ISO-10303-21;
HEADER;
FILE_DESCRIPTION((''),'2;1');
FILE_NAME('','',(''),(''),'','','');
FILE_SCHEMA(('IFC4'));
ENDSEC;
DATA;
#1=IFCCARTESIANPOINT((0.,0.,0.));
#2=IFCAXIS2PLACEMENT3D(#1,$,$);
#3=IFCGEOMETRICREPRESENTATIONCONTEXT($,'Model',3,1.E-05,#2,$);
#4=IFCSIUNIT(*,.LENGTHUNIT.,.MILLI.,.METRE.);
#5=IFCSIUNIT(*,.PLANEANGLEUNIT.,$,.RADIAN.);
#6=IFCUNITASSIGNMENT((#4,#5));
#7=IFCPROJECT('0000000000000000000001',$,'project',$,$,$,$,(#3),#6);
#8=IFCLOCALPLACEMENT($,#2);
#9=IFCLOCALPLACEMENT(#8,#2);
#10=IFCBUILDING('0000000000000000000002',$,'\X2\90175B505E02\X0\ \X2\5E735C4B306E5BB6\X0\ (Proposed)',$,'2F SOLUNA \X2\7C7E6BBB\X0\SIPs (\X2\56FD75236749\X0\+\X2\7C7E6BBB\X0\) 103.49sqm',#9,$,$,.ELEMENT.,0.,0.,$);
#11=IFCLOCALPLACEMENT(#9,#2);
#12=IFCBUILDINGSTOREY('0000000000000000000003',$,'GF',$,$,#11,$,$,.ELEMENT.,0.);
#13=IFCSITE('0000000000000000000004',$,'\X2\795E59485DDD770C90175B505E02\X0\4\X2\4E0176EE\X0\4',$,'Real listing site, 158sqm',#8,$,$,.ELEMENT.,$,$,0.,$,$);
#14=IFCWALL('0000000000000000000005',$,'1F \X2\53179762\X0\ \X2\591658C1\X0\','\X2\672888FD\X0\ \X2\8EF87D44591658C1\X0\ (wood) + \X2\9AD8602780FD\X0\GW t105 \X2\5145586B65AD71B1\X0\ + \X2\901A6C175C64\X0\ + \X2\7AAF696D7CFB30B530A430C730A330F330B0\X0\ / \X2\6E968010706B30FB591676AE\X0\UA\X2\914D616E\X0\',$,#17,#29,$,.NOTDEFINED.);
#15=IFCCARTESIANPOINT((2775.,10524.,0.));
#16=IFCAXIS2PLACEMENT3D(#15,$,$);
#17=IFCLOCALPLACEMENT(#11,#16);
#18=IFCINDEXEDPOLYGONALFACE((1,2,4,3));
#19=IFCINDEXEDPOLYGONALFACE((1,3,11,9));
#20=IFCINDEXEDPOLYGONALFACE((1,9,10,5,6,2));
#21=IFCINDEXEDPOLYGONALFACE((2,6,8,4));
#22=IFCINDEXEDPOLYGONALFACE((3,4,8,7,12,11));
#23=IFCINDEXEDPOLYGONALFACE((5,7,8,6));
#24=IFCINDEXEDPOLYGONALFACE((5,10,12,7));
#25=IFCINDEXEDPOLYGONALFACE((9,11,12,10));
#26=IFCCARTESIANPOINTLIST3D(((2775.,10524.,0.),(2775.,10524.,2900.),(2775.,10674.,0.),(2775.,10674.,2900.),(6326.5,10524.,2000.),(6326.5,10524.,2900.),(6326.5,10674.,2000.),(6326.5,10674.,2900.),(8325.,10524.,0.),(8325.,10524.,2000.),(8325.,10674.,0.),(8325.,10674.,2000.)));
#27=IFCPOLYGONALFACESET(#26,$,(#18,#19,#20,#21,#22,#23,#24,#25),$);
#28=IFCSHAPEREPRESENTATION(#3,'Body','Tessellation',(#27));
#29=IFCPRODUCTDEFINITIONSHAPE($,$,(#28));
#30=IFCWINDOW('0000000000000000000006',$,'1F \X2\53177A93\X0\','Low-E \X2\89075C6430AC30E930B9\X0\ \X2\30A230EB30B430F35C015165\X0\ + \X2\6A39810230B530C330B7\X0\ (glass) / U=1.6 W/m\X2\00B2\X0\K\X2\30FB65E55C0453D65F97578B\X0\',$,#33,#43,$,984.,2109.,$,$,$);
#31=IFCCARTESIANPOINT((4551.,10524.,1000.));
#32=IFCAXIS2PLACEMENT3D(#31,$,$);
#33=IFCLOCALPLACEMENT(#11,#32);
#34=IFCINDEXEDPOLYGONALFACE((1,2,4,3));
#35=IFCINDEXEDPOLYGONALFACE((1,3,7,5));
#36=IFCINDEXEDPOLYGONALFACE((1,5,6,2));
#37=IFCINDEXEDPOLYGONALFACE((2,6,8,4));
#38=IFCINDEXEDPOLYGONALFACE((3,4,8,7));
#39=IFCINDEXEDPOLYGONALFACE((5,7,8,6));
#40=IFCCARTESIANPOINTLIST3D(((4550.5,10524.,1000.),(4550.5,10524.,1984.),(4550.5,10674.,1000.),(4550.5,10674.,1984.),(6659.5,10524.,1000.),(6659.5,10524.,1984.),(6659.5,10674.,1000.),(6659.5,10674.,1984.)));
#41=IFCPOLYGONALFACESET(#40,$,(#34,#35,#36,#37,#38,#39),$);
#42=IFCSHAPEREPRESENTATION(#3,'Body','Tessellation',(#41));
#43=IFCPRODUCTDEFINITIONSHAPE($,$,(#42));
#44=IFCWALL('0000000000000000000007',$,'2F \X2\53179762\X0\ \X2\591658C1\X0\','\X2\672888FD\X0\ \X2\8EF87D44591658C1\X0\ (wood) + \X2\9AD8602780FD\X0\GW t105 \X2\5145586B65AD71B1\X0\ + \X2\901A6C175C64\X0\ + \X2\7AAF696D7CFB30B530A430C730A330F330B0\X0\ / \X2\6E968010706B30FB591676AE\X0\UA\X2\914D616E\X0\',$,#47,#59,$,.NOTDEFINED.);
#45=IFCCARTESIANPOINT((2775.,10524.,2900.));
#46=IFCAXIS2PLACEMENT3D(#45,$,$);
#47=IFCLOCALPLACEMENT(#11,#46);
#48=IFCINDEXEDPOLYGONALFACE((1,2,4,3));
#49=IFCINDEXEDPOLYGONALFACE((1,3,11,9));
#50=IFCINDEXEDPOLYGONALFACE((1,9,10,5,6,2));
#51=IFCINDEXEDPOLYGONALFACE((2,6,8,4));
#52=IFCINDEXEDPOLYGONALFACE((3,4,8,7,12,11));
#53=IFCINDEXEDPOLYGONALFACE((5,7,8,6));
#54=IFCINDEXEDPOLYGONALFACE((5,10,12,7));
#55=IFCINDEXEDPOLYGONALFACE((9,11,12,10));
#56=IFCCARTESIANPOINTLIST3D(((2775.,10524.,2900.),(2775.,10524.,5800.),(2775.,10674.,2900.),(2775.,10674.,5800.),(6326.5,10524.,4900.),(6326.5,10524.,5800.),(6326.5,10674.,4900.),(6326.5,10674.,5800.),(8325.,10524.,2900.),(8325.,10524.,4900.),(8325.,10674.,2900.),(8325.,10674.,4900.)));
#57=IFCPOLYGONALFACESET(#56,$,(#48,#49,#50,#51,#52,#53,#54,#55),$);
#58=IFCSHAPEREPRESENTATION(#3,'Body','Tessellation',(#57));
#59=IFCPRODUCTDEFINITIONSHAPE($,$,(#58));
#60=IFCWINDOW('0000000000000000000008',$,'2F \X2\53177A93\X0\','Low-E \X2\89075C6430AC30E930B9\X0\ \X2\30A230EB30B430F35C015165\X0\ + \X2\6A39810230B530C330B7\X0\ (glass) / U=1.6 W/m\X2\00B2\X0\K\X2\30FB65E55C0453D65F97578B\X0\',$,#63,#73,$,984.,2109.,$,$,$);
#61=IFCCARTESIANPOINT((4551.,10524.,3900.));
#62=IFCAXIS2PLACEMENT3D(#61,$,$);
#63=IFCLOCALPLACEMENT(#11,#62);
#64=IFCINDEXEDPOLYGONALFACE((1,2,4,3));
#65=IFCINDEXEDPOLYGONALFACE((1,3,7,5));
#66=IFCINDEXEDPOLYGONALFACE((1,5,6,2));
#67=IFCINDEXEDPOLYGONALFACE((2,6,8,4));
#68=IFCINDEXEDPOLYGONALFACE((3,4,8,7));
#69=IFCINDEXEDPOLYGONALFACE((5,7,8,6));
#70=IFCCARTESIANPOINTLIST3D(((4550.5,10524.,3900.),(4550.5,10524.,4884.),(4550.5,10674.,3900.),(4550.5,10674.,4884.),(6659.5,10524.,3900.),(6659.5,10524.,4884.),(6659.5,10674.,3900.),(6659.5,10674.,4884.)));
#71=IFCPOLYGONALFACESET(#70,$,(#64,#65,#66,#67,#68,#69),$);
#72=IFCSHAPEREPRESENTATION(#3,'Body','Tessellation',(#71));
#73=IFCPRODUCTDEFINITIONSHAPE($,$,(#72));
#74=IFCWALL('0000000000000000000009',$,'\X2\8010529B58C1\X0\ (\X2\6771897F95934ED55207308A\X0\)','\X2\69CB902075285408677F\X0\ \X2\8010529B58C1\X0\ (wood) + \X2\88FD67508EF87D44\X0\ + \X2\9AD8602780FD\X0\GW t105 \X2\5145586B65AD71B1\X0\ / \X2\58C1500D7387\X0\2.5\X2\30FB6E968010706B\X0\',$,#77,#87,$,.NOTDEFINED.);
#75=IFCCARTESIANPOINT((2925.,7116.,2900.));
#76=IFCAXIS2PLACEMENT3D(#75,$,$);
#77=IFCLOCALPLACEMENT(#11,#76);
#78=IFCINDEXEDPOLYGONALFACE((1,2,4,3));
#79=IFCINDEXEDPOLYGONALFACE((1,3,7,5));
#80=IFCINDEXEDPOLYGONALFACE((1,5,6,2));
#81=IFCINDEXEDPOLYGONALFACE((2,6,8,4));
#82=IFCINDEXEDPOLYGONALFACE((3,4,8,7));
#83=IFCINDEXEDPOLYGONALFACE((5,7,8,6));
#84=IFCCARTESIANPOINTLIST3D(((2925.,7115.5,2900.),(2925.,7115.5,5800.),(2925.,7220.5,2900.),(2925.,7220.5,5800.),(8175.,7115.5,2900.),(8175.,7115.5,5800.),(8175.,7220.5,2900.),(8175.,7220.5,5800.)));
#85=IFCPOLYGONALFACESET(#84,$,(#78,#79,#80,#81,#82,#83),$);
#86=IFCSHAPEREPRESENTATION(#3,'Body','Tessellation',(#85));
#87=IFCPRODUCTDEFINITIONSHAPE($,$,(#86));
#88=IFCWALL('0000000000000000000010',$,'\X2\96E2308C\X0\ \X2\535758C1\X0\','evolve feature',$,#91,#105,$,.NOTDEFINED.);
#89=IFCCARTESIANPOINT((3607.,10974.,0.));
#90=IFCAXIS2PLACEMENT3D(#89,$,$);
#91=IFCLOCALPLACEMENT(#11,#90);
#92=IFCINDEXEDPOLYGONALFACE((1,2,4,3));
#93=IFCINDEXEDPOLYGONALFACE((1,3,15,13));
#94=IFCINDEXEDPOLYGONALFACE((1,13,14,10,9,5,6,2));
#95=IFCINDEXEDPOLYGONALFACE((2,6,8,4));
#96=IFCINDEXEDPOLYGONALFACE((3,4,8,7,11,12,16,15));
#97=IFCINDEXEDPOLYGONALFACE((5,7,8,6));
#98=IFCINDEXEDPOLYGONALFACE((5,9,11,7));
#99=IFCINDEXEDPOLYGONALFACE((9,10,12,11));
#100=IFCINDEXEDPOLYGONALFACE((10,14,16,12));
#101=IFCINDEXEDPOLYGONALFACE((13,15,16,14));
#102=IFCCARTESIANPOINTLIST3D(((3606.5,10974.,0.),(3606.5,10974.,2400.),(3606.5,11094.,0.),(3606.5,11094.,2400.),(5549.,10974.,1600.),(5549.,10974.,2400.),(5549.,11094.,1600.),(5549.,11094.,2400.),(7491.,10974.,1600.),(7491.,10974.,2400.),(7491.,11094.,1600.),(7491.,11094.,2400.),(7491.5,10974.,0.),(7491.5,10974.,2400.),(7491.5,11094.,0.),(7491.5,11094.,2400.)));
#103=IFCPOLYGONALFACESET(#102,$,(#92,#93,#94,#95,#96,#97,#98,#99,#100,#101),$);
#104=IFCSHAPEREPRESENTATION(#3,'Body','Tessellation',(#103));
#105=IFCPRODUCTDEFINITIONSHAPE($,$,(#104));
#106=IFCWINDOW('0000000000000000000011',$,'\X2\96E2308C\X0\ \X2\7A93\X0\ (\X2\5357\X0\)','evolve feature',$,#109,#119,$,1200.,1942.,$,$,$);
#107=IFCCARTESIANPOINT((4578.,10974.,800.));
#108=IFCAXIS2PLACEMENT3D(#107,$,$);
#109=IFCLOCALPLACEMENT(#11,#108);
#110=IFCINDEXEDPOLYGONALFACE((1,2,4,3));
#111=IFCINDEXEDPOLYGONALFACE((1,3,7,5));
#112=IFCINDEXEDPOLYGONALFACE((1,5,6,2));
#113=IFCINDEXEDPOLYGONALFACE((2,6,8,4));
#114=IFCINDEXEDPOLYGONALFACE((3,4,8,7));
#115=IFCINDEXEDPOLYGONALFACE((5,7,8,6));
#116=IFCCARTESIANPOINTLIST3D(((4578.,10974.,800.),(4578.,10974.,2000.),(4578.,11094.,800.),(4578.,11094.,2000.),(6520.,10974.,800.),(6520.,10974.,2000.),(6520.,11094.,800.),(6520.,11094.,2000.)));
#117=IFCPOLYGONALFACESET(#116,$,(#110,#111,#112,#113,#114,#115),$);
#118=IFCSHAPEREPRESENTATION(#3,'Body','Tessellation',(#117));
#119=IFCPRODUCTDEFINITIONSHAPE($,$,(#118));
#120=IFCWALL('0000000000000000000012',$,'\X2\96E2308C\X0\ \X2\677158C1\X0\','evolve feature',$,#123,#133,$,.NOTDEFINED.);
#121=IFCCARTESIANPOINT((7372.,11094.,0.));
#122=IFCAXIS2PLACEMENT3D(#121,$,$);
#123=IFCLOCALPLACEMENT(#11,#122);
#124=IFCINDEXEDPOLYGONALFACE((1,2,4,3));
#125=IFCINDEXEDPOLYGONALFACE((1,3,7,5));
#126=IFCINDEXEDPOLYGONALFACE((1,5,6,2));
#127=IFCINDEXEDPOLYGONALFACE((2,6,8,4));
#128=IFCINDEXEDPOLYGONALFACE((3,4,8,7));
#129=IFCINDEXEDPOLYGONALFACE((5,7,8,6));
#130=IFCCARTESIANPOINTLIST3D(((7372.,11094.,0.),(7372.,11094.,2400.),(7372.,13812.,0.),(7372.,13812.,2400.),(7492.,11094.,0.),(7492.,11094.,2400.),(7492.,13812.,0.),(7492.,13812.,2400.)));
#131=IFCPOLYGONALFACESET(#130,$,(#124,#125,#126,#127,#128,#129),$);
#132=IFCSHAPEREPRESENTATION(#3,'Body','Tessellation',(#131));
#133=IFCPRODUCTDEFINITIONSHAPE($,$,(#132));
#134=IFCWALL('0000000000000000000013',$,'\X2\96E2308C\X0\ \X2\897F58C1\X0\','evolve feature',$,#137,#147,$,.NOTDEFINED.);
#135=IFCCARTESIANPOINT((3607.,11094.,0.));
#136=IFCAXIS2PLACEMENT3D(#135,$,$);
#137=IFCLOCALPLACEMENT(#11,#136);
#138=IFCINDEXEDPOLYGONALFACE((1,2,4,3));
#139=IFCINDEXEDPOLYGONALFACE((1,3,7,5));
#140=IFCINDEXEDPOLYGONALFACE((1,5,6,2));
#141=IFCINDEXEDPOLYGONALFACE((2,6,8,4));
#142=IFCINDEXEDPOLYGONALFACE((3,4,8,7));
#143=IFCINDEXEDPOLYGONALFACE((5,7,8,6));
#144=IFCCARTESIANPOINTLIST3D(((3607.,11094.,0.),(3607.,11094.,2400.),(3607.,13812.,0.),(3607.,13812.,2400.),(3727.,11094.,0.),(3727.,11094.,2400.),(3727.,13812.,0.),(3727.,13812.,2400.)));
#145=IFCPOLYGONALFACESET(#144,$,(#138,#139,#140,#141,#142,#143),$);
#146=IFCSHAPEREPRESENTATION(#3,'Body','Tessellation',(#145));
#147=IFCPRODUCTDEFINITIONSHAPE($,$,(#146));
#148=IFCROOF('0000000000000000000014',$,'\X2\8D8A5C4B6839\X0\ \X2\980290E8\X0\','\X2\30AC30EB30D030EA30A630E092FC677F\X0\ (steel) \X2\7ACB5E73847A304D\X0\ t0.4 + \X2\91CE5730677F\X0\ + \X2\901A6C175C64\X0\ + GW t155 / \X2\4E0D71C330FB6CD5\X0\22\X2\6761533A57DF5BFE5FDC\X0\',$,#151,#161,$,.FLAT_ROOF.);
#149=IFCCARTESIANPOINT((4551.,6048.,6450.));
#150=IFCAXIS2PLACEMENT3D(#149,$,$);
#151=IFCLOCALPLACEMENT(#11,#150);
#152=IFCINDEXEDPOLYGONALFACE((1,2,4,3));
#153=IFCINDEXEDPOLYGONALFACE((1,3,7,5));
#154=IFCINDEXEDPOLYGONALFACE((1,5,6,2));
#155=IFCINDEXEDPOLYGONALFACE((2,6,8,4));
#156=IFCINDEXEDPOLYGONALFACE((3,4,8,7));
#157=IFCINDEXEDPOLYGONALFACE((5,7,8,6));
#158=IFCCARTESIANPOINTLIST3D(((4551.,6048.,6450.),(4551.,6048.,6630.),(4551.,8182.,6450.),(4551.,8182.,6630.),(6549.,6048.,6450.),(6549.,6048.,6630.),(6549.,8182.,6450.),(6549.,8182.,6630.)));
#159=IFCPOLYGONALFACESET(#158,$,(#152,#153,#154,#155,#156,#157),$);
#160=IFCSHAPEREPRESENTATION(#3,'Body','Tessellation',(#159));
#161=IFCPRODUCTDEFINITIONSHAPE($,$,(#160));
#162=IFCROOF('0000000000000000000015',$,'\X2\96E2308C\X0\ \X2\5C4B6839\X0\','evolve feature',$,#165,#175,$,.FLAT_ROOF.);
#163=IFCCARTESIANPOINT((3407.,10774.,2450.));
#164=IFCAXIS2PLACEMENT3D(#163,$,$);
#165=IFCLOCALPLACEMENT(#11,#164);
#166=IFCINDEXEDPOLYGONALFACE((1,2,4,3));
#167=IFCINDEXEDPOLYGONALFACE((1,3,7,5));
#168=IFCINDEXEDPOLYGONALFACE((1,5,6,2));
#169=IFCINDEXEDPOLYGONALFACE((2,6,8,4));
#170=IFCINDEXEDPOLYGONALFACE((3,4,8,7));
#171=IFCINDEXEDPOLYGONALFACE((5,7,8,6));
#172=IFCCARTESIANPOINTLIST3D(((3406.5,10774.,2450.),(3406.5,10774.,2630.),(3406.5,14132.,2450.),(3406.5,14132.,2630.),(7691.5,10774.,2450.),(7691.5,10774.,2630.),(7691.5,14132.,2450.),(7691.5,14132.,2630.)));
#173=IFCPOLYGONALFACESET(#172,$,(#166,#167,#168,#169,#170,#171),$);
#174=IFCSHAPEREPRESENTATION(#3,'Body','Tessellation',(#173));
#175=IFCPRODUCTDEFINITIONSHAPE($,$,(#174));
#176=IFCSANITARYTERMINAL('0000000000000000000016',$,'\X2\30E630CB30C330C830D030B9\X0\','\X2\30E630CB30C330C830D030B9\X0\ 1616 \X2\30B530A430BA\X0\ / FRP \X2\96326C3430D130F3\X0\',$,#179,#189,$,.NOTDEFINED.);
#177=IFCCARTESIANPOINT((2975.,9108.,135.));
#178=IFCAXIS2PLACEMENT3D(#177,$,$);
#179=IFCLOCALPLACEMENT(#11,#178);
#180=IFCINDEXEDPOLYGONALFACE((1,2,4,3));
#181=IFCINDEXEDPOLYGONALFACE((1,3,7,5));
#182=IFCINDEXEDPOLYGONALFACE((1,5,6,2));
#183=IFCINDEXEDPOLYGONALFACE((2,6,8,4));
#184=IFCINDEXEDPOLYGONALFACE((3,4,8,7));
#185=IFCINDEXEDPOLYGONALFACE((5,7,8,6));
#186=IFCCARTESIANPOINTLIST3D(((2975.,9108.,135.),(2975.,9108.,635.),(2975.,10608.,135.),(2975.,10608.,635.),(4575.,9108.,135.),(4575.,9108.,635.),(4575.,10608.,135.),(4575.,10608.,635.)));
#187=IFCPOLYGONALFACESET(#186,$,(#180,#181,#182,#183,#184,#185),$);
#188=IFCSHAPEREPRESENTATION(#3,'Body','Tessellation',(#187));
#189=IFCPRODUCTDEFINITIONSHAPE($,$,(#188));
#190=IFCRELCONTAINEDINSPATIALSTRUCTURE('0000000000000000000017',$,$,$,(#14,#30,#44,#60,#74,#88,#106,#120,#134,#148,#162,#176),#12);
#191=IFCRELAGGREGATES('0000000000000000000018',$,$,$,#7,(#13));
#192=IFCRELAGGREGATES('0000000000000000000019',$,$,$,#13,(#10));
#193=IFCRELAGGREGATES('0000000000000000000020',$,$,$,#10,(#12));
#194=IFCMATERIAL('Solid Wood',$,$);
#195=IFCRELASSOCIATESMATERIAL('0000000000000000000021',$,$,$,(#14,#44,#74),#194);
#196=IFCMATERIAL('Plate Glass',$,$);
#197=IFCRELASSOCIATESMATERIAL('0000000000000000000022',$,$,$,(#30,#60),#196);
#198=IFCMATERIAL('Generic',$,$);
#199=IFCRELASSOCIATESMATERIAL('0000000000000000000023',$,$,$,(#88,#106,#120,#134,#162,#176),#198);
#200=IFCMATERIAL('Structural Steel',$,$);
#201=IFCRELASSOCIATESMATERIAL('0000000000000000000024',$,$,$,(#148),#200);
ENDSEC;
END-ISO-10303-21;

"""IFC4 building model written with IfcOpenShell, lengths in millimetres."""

from ifc_helpers import new_model, si_unit, frame, frame_2d, origin, place, context, project, spatial, rectangle, extrude, material, element, fill, save


model = new_model("IFC4")

# Units and contexts
model_context = context("Model", 3, precision=1e-05, world=origin())
ifc_project = project(units=[si_unit("LENGTHUNIT", "METRE", prefix="MILLI"), si_unit("PLANEANGLEUNIT", "RADIAN")], contexts=[model_context])

# Site, building, storey
site_placement = place(None, origin())
site = spatial("IfcSite", under=ifc_project, at=site_placement, Name="神奈川県逗子市4丁目4", ObjectType="Real listing site, 158sqm", CompositionType="ELEMENT", RefElevation=0.0)
building_placement = place(site_placement, origin())
building = spatial("IfcBuilding", under=site, at=building_placement, Name="逗子市 平屋の家 (Proposed)", ObjectType="2F SOLUNA 籾殻SIPs (国産杉+籾殻) 103.49sqm", CompositionType="ELEMENT", ElevationOfRefHeight=0.0, ElevationOfTerrain=0.0)
storey_placement = place(building_placement, origin())
storey = spatial("IfcBuildingStorey", under=building, at=storey_placement, Name="GF", CompositionType="ELEMENT", Elevation=0.0)

# Shared definitions
ifc_material_1 = material(Name="Generic")

# Wall, opening, window
ifc_material_2 = material(Name="Solid Wood")
wall_1_placement = place(storey_placement, frame((2775.0, 10524.0, 0.0)))
wall_1 = element("IfcWall", 1, at=wall_1_placement, inside=storey, material=ifc_material_2, Name="1F 北面 外壁", Description="木製 軸組外壁 (wood) + 高性能GW t105 充填断熱 + 通気層 + 窯業系サイディング / 準耐火・外皮UA配慮", PredefinedType="NOTDEFINED", context=model_context, shape_type="SweptSolid", body=[
    extrude(rectangle(XDim=5550.0, YDim=150.0, at=frame_2d((2775.0, 75.0))), frame((2775.0, 10524.0, 0.0)), (0.0, 0.0, 1.0), 2900.0),
])
opening_1_placement = place(storey_placement, frame((4551.0, 10524.0, 1000.0)))
opening_1 = element("IfcOpeningElement", 2, at=opening_1_placement, cuts=wall_1, PredefinedType="NOTDEFINED", context=model_context, shape_type="SweptSolid", body=[
    extrude(rectangle(XDim=2109.0, YDim=150.0, at=frame_2d((1054.0, 75.0))), frame((4551.0, 10524.0, 1000.0)), (0.0, 0.0, 1.0), 984.0),
])
ifc_material_3 = material(Name="Plate Glass")
window_1_placement = place(storey_placement, frame((4551.0, 10524.0, 1000.0)))
window_1 = element("IfcWindow", 3, at=window_1_placement, inside=storey, material=ifc_material_3, Name="1F 北窓", Description="Low-E 複層ガラス アルゴン封入 + 樹脂サッシ (glass) / U=1.6 W/m²K・日射取得型", OverallHeight=984.0, OverallWidth=2109.0, context=model_context, shape_type="SweptSolid", body=[
    extrude(rectangle(XDim=2109.0, YDim=150.0, at=frame_2d((1054.0, 75.0))), frame((4551.0, 10524.0, 1000.0)), (0.0, 0.0, 1.0), 984.0),
])
fill(opening_1, window_1)

# Wall, opening, window
wall_2_placement = place(storey_placement, frame((2775.0, 10524.0, 2900.0)))
wall_2 = element("IfcWall", 4, at=wall_2_placement, inside=storey, material=ifc_material_2, Name="2F 北面 外壁", Description="木製 軸組外壁 (wood) + 高性能GW t105 充填断熱 + 通気層 + 窯業系サイディング / 準耐火・外皮UA配慮", PredefinedType="NOTDEFINED", context=model_context, shape_type="SweptSolid", body=[
    extrude(rectangle(XDim=5550.0, YDim=150.0, at=frame_2d((2775.0, 75.0))), frame((2775.0, 10524.0, 2900.0)), (0.0, 0.0, 1.0), 2900.0),
])
opening_2_placement = place(storey_placement, frame((4551.0, 10524.0, 3900.0)))
opening_2 = element("IfcOpeningElement", 5, at=opening_2_placement, cuts=wall_2, PredefinedType="NOTDEFINED", context=model_context, shape_type="SweptSolid", body=[
    extrude(rectangle(XDim=2109.0, YDim=150.0, at=frame_2d((1054.0, 75.0))), frame((4551.0, 10524.0, 3900.0)), (0.0, 0.0, 1.0), 984.0),
])
window_2_placement = place(storey_placement, frame((4551.0, 10524.0, 3900.0)))
window_2 = element("IfcWindow", 6, at=window_2_placement, inside=storey, material=ifc_material_3, Name="2F 北窓", Description="Low-E 複層ガラス アルゴン封入 + 樹脂サッシ (glass) / U=1.6 W/m²K・日射取得型", OverallHeight=984.0, OverallWidth=2109.0, context=model_context, shape_type="SweptSolid", body=[
    extrude(rectangle(XDim=2109.0, YDim=150.0, at=frame_2d((1054.0, 75.0))), frame((4551.0, 10524.0, 3900.0)), (0.0, 0.0, 1.0), 984.0),
])
fill(opening_2, window_2)

# Wall
wall_3_placement = place(storey_placement, frame((2925.0, 7116.0, 2900.0)))
element("IfcWall", 7, at=wall_3_placement, inside=storey, material=ifc_material_2, Name="耐力壁 (東西間仕切り)", Description="構造用合板 耐力壁 (wood) + 製材軸組 + 高性能GW t105 充填断熱 / 壁倍率2.5・準耐火", PredefinedType="NOTDEFINED", context=model_context, shape_type="SweptSolid", body=[
    extrude(rectangle(XDim=5250.0, YDim=105.0, at=frame_2d((2625.0, 52.0))), frame((2925.0, 7116.0, 2900.0)), (0.0, 0.0, 1.0), 2900.0),
])

# Wall, opening, window
wall_4_placement = place(storey_placement, frame((3607.0, 10974.0, 0.0)))
wall_4 = element("IfcWall", 8, at=wall_4_placement, inside=storey, material=ifc_material_1, Name="離れ 南壁", Description="evolve feature", PredefinedType="NOTDEFINED", context=model_context, shape_type="SweptSolid", body=[
    extrude(rectangle(XDim=3885.0, YDim=120.0, at=frame_2d((1942.0, 60.0))), frame((3607.0, 10974.0, 0.0)), (0.0, 0.0, 1.0), 2400.0),
])
opening_3_placement = place(storey_placement, frame((4578.0, 10974.0, 800.0)))
opening_3 = element("IfcOpeningElement", 9, at=opening_3_placement, cuts=wall_4, PredefinedType="NOTDEFINED", context=model_context, shape_type="SweptSolid", body=[
    extrude(rectangle(XDim=1942.0, YDim=120.0, at=frame_2d((971.0, 60.0))), frame((4578.0, 10974.0, 800.0)), (0.0, 0.0, 1.0), 1200.0),
])
window_3_placement = place(storey_placement, frame((4578.0, 10974.0, 800.0)))
window_3 = element("IfcWindow", 10, at=window_3_placement, inside=storey, material=ifc_material_1, Name="離れ 窓 (南)", Description="evolve feature", OverallHeight=1200.0, OverallWidth=1942.0, context=model_context, shape_type="SweptSolid", body=[
    extrude(rectangle(XDim=1942.0, YDim=120.0, at=frame_2d((971.0, 60.0))), frame((4578.0, 10974.0, 800.0)), (0.0, 0.0, 1.0), 1200.0),
])
fill(opening_3, window_3)

# Walls
wall_5_placement = place(storey_placement, frame((7372.0, 11094.0, 0.0)))
element("IfcWall", 11, at=wall_5_placement, inside=storey, material=ifc_material_1, Name="離れ 東壁", Description="evolve feature", PredefinedType="NOTDEFINED", context=model_context, shape_type="SweptSolid", body=[
    extrude(rectangle(XDim=120.0, YDim=2718.0, at=frame_2d((60.0, 1359.0))), frame((7372.0, 11094.0, 0.0)), (0.0, 0.0, 1.0), 2400.0),
])
wall_6_placement = place(storey_placement, frame((3607.0, 11094.0, 0.0)))
element("IfcWall", 12, at=wall_6_placement, inside=storey, material=ifc_material_1, Name="離れ 西壁", Description="evolve feature", PredefinedType="NOTDEFINED", context=model_context, shape_type="SweptSolid", body=[
    extrude(rectangle(XDim=120.0, YDim=2718.0, at=frame_2d((60.0, 1359.0))), frame((3607.0, 11094.0, 0.0)), (0.0, 0.0, 1.0), 2400.0),
])

# Roofs
ifc_material_4 = material(Name="Structural Steel")
roof_1_placement = place(storey_placement, frame((4551.0, 6048.0, 6450.0)))
element("IfcRoof", 13, at=roof_1_placement, inside=storey, material=ifc_material_4, Name="越屋根 頂部", Description="ガルバリウム鋼板 (steel) 立平葺き t0.4 + 野地板 + 通気層 + GW t155 / 不燃・法22条区域対応", PredefinedType="FLAT_ROOF", context=model_context, shape_type="SweptSolid", body=[
    extrude(rectangle(XDim=1998.0, YDim=2134.0, at=frame_2d((999.0, 1067.0))), frame((4551.0, 6048.0, 6450.0)), (0.0, 0.0, 1.0), 180.0),
])
roof_2_placement = place(storey_placement, frame((3407.0, 10774.0, 2450.0)))
element("IfcRoof", 14, at=roof_2_placement, inside=storey, material=ifc_material_1, Name="離れ 屋根", Description="evolve feature", PredefinedType="FLAT_ROOF", context=model_context, shape_type="SweptSolid", body=[
    extrude(rectangle(XDim=4285.0, YDim=3358.0, at=frame_2d((2142.0, 1679.0))), frame((3407.0, 10774.0, 2450.0)), (0.0, 0.0, 1.0), 180.0),
])

# Sanitary terminal
sanitary_terminal_1_placement = place(storey_placement, frame((2975.0, 9108.0, 135.0)))
element("IfcSanitaryTerminal", 15, at=sanitary_terminal_1_placement, inside=storey, material=ifc_material_1, Name="ユニットバス", Description="ユニットバス 1616 サイズ / FRP 防水パン", PredefinedType="NOTDEFINED", context=model_context, shape_type="SweptSolid", body=[
    extrude(rectangle(XDim=1600.0, YDim=1500.0, at=frame_2d((800.0, 750.0))), frame((2975.0, 9108.0, 135.0)), (0.0, 0.0, 1.0), 500.0),
])

save(model, "model.ifc")
